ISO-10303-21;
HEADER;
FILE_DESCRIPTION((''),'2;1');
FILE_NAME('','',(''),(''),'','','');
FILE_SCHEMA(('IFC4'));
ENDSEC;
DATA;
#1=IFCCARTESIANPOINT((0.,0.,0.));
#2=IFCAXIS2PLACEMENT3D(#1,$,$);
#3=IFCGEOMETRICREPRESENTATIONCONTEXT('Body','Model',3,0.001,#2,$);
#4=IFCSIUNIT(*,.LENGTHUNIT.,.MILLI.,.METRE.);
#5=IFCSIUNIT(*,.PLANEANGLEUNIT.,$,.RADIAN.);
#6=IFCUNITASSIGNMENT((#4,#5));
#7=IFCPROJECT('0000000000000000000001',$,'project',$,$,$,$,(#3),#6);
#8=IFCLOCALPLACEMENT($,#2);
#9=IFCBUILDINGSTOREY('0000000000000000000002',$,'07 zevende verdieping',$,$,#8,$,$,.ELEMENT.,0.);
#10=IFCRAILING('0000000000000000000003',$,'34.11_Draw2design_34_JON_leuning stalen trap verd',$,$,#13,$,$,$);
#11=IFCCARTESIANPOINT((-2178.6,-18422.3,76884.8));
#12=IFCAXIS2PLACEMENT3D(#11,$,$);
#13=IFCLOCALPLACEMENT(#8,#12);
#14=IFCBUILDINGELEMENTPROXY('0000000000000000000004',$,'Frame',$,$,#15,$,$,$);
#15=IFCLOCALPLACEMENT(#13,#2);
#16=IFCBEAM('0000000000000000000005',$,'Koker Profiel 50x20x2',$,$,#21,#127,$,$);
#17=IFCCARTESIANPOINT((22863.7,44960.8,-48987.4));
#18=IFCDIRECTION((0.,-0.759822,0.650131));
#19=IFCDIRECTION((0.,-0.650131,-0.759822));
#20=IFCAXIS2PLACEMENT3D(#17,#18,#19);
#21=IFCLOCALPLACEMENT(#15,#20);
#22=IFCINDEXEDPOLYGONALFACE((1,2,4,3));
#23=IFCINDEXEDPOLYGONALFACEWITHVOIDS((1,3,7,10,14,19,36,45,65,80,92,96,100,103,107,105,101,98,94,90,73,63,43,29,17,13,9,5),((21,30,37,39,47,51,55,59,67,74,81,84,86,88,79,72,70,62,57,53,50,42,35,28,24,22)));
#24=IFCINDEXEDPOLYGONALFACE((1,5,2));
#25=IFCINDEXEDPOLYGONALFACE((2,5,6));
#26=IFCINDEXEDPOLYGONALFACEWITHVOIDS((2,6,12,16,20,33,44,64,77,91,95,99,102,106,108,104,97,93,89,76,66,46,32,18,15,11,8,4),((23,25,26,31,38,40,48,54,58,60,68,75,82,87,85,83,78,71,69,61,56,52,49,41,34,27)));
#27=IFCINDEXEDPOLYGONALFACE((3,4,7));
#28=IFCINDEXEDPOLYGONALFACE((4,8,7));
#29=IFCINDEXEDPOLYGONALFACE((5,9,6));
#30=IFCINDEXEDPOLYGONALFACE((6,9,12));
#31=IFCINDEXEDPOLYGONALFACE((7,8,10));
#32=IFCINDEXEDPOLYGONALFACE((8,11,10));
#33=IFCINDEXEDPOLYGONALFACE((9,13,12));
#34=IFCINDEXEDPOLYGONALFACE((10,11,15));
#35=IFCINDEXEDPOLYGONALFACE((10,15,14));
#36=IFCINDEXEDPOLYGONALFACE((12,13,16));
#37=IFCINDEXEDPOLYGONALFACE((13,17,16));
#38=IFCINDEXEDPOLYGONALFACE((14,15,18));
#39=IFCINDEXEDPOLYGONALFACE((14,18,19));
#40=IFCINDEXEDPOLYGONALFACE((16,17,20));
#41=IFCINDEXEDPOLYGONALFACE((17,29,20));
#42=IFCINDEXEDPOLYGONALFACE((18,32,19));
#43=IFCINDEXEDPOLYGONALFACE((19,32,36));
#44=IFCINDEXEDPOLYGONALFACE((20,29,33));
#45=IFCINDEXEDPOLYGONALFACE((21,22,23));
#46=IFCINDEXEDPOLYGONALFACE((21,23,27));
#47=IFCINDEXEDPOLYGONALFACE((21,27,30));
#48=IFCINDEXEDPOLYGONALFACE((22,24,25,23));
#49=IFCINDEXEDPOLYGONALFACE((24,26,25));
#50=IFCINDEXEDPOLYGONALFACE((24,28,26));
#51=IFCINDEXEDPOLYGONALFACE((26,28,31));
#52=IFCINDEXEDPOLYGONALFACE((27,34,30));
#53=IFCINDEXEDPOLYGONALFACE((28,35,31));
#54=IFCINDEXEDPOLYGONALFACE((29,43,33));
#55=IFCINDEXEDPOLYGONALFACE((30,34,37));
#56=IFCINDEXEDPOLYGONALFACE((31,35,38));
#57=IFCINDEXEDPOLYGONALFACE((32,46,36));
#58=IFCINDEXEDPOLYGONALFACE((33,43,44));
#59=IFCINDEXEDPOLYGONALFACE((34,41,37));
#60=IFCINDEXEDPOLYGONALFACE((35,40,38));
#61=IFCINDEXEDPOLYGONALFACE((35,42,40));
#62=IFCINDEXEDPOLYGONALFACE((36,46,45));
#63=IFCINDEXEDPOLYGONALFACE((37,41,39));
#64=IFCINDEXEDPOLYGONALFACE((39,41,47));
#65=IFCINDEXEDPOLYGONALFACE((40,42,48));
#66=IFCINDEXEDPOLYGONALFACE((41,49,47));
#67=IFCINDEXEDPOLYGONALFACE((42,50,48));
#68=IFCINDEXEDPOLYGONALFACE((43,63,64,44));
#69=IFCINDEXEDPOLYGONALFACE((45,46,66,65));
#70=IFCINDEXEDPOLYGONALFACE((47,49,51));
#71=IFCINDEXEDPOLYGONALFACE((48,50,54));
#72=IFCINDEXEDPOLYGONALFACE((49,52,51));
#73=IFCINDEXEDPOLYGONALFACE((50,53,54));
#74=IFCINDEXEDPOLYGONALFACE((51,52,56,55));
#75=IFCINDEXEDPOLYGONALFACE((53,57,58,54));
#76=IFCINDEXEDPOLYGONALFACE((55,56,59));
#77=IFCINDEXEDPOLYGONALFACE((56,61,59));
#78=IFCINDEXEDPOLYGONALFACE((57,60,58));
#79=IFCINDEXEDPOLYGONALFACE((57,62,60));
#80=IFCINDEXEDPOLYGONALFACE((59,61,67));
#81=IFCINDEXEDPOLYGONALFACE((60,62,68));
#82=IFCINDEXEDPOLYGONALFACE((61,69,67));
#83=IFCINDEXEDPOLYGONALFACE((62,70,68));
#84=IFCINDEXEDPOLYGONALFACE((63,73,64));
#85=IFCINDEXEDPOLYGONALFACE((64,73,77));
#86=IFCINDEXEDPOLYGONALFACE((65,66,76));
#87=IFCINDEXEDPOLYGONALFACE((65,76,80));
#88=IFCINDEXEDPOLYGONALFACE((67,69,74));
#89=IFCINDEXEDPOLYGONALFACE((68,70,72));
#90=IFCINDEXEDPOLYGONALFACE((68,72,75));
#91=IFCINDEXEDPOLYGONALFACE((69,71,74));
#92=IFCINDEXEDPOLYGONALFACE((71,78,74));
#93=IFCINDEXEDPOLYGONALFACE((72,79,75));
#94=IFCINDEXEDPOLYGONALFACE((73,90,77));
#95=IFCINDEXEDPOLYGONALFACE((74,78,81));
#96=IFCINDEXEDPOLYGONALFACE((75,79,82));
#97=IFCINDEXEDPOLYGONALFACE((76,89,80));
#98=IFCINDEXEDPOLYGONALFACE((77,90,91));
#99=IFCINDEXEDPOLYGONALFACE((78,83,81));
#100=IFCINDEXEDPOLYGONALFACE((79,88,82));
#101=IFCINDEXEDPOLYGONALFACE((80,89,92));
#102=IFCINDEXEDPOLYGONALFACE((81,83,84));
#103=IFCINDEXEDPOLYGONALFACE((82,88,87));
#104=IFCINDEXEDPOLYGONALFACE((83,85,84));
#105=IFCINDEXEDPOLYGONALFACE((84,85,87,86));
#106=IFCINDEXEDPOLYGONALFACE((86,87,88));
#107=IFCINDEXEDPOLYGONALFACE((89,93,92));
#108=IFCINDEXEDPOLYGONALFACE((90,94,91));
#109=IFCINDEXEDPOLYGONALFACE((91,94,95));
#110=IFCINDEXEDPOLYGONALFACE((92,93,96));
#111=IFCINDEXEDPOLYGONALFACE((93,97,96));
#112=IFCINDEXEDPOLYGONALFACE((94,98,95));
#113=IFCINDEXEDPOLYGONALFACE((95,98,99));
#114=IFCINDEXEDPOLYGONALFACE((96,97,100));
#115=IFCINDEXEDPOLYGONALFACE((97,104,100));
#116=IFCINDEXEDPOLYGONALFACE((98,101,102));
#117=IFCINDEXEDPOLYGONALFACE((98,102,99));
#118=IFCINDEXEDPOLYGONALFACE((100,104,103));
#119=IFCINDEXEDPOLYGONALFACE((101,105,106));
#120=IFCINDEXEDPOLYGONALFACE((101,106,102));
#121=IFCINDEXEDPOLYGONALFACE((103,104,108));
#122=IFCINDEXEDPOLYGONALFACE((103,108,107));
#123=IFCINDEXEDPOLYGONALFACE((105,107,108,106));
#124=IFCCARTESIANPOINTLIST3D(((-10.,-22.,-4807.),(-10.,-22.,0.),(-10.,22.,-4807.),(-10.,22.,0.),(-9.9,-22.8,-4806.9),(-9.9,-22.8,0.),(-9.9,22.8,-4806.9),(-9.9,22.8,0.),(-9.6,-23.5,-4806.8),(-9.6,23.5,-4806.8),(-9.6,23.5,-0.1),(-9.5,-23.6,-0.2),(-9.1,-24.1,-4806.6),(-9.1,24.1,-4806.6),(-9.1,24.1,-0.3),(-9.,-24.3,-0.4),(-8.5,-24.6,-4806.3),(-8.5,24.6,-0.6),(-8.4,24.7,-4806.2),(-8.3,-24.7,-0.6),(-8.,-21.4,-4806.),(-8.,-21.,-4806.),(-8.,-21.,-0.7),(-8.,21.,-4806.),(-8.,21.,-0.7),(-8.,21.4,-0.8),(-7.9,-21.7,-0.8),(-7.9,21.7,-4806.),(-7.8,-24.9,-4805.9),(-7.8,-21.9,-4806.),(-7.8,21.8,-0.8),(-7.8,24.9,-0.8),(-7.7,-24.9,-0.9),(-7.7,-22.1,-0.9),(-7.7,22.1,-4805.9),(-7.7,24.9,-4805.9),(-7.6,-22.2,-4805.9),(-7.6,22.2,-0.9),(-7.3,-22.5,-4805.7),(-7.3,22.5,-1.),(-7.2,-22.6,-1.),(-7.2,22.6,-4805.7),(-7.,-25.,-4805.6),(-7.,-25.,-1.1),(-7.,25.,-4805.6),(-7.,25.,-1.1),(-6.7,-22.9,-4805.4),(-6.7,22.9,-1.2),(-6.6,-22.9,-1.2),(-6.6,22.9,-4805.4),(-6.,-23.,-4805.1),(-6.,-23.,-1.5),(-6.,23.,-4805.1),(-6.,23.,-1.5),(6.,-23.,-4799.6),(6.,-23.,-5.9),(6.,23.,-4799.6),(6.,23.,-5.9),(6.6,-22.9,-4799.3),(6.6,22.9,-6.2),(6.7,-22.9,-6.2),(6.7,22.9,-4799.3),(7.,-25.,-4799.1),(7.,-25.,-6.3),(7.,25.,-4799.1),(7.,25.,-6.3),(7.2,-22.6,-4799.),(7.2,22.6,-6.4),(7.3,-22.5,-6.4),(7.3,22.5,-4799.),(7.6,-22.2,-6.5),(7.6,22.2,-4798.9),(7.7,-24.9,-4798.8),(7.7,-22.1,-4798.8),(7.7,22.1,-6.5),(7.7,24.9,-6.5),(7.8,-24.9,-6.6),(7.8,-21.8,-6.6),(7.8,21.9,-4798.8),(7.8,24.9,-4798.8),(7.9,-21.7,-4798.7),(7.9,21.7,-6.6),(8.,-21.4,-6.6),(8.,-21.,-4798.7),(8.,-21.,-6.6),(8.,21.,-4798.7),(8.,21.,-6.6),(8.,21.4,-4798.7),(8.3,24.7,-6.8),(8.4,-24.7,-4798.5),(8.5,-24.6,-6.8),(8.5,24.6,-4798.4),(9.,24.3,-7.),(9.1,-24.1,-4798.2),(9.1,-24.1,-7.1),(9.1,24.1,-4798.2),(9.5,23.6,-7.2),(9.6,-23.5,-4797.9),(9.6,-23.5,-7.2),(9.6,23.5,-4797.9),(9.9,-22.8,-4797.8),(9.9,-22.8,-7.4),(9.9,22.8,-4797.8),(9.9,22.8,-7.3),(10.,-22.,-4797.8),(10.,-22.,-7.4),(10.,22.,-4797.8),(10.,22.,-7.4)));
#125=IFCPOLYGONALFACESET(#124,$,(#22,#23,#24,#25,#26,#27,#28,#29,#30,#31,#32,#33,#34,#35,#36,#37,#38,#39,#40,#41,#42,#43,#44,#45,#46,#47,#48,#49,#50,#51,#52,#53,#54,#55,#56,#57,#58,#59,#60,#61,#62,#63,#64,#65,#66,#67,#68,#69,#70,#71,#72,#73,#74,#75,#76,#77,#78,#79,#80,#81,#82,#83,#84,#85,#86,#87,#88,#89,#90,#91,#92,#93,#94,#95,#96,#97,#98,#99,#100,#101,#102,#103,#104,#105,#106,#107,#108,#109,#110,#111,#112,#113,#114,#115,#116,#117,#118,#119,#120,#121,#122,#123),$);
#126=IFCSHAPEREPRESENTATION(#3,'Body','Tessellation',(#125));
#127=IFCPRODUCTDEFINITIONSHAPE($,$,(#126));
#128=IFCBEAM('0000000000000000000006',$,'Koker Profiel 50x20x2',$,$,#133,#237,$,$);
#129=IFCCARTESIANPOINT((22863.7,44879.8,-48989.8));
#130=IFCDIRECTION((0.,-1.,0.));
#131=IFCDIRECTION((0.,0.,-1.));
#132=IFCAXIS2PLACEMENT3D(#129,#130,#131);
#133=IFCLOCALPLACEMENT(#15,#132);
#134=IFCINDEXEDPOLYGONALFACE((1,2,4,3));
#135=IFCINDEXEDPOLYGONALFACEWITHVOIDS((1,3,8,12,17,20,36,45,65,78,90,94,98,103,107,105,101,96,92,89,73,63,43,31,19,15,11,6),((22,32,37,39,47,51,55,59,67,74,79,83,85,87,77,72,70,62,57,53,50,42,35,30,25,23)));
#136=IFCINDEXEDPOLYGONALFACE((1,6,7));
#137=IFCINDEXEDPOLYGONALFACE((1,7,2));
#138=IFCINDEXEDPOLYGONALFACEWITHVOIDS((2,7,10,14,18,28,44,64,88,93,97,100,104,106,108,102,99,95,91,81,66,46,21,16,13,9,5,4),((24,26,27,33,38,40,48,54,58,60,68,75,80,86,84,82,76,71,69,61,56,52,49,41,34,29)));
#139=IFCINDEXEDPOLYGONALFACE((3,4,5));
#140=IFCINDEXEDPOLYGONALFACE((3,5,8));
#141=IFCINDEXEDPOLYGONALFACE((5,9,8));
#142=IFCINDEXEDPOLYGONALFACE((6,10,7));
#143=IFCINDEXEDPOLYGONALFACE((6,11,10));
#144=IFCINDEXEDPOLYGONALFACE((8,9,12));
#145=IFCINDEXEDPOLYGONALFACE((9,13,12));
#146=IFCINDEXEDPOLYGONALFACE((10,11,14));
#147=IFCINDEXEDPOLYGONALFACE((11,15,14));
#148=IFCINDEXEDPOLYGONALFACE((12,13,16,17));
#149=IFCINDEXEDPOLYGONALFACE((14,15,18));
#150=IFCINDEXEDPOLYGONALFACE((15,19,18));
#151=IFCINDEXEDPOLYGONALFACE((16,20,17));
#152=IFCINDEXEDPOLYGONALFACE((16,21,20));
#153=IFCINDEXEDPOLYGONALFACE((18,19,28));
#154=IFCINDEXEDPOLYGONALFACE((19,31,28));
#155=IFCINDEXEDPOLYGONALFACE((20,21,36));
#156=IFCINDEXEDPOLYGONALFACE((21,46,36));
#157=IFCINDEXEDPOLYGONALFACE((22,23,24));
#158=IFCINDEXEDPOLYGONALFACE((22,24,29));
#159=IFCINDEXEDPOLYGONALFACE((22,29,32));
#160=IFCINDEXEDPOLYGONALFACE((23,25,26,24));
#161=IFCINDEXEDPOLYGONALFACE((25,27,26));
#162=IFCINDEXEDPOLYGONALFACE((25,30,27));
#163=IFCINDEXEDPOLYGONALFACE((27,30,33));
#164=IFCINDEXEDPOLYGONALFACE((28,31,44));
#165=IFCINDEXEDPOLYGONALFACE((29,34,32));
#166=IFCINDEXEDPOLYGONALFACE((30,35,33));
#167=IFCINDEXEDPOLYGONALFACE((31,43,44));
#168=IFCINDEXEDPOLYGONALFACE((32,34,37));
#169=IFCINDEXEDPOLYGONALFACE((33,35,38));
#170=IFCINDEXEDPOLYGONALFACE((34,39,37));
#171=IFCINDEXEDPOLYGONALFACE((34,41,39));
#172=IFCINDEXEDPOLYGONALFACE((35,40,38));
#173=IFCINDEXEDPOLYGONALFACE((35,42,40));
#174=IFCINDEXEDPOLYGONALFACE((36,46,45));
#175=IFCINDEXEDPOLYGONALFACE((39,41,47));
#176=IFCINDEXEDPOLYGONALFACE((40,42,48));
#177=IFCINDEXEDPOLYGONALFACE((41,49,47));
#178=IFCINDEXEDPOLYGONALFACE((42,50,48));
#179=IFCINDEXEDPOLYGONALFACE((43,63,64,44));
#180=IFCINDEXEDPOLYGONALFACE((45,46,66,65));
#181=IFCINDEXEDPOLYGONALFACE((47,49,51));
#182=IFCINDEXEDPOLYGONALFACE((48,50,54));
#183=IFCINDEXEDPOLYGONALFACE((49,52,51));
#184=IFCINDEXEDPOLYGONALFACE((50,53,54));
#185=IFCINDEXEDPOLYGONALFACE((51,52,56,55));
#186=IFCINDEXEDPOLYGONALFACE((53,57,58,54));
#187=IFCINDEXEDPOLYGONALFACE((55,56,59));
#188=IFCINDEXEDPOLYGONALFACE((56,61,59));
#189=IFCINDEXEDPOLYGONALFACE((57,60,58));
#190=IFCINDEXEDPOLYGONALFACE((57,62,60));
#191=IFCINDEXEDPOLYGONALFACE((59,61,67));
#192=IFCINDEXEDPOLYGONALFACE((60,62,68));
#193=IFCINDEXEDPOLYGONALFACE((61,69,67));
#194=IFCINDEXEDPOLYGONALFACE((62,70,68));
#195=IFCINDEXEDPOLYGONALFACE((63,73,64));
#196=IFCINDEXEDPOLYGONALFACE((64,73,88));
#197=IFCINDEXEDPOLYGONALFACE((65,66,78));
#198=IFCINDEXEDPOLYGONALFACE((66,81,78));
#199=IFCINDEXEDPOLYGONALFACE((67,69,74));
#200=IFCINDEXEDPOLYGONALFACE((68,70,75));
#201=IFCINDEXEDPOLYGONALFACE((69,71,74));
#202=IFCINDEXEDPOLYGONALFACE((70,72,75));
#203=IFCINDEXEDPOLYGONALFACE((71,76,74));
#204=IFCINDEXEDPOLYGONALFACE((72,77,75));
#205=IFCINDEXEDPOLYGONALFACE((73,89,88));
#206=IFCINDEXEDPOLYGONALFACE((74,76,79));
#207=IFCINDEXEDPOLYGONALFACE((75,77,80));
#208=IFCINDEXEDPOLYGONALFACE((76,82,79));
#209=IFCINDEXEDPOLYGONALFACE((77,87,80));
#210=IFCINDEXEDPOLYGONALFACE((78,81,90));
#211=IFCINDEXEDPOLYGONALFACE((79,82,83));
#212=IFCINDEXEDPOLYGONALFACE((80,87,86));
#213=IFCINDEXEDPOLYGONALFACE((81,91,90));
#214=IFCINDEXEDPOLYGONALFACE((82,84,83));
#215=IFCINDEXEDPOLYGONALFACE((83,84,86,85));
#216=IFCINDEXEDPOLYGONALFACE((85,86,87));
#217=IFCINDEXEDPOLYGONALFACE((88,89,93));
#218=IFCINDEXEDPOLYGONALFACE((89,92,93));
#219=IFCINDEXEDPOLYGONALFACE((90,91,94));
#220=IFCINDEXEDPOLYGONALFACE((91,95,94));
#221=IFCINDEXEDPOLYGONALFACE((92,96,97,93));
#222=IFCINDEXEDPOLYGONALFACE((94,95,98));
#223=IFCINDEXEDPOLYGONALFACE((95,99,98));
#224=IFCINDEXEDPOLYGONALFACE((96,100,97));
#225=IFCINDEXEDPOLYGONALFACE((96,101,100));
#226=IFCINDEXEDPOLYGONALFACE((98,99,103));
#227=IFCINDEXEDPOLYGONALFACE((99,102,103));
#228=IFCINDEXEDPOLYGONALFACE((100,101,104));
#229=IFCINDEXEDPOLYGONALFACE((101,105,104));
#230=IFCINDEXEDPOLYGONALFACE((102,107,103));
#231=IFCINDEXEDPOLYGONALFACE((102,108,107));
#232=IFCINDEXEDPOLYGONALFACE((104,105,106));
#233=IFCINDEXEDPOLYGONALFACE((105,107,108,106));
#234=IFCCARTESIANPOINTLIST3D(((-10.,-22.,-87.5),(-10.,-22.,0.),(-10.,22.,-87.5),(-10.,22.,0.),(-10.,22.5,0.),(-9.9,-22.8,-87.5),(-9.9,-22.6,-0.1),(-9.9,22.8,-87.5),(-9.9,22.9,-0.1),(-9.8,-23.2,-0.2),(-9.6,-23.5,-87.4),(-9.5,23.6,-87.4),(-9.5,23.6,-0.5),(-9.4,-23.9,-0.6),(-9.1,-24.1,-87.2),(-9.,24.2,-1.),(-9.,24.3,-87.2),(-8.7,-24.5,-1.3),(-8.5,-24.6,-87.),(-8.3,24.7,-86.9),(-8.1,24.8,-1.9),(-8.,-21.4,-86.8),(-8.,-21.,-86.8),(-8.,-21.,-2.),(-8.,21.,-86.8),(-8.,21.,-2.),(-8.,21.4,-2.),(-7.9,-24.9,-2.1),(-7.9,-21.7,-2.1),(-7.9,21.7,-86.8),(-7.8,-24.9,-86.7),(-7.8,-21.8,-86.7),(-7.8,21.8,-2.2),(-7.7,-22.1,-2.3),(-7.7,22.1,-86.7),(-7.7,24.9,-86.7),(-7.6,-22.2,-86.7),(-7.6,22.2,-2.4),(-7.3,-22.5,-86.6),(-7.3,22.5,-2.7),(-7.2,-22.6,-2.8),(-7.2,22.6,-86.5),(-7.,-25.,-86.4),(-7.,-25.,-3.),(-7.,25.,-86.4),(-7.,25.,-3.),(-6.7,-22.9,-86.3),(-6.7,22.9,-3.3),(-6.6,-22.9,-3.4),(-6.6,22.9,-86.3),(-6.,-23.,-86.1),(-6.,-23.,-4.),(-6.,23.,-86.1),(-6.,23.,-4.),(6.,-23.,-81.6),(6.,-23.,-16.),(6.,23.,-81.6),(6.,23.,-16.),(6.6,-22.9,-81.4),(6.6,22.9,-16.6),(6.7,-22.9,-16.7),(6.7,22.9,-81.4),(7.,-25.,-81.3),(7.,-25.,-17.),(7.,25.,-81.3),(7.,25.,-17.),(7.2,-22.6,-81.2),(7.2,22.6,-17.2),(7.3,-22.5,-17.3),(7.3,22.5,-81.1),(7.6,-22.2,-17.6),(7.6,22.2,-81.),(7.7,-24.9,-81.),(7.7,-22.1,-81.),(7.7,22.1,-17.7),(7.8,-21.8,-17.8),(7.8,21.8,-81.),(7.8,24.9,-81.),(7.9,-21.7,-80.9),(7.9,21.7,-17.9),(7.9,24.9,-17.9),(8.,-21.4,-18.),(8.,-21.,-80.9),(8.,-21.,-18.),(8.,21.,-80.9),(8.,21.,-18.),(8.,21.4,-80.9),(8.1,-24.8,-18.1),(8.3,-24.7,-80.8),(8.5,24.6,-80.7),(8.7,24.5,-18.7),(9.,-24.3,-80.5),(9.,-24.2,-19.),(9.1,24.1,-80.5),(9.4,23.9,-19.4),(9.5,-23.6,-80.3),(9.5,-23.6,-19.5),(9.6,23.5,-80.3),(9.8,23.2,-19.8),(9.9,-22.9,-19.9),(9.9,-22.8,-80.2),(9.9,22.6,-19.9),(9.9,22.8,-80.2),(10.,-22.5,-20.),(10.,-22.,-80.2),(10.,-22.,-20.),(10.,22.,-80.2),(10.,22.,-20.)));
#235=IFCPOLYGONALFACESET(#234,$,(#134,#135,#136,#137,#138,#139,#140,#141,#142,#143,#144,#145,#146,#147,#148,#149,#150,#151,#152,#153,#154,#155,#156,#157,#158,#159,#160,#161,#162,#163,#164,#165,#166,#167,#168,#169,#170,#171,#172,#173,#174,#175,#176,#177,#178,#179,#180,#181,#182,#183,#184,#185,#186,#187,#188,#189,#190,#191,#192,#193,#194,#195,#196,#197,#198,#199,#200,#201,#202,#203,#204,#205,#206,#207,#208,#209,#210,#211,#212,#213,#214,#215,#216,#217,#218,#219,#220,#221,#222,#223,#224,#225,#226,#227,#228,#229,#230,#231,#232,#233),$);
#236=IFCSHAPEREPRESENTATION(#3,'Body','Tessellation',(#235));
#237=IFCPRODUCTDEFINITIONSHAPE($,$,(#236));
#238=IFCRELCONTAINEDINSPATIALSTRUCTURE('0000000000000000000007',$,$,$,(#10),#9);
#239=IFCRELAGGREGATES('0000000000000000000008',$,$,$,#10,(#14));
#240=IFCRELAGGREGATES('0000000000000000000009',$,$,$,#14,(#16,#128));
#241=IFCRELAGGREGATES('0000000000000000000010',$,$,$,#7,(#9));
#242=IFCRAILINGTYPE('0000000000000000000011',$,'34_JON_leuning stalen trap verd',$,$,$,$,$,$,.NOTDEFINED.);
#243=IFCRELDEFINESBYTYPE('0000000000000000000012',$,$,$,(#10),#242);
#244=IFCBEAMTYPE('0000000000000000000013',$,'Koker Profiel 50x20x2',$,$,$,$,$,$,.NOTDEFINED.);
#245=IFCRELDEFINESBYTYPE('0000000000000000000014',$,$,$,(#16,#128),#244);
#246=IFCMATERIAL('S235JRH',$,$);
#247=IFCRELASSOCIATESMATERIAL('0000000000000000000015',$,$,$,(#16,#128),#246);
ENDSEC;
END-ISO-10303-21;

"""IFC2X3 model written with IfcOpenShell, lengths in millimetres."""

from ifc_helpers import new_model, si_unit, frame, origin, origin_2d, place, context, project, spatial, hollow_rectangle, extrude, clip, halfspace, source, transform, mapped, material, type_object, element, aggregate, save


model = new_model("IFC2X3")

# Units and contexts
model_context = context("Model", 3, precision=0.001, world=origin(), identifier="Body")
ifc_project = project(units=[si_unit("LENGTHUNIT", "METRE", prefix="MILLI"), si_unit("PLANEANGLEUNIT", "RADIAN")], contexts=[model_context])

# Storey
storey_placement = place(None, origin())
storey = spatial("IfcBuildingStorey", under=ifc_project, at=storey_placement, Name="07 zevende verdieping", CompositionType="ELEMENT", Elevation=0.0)

# Railing
railing_type_1 = type_object("IfcRailingType", Name="34_JON_leuning stalen trap verd")
railing_1_placement = place(storey_placement, frame((-2178.6, -18422.3, 76884.8)))
railing_1 = element("IfcRailing", 1, at=railing_1_placement, inside=storey, type_object=railing_type_1, Name="34.11_Draw2design_34_JON_leuning stalen trap verd")
ifc_material_1 = material(Name="S235JRH")

# Shared definitions
beam_type_1 = type_object("IfcBeamType", Name="Koker Profiel 50x20x2")

# Building element proxy
proxy_1_placement = place(railing_1_placement, origin())
proxy_1 = element("IfcBuildingElementProxy", 2, at=proxy_1_placement, Name="Frame")
aggregate(railing_1, [proxy_1])

# Beams
shared_shape_1 = source(origin(), model_context, "Body", "Clipping", [
    clip(clip(extrude(hollow_rectangle(XDim=20.0, YDim=50.0, WallThickness=2.0, InnerFilletRadius=2.0, OuterFilletRadius=3.0, at=origin_2d()), origin(), (0.0, 0.0, -1.0), 4807.0), halfspace(frame((-8.8, -25.0, -0.5), z_axis=(0.346539, 0.0, 0.938036), x_axis=(0.0, -1.0, 0.0)), False)), halfspace(frame((-8.2, 25.0, -4806.1), z_axis=(0.418252, 0.0, -0.908331), x_axis=(-0.908331, 0.0, -0.418252)), False)),
])
beam_1_placement = place(proxy_1_placement, frame((22863.7, 44960.8, -48987.4), z_axis=(0.0, -0.759822, 0.650131), x_axis=(0.0, -0.650131, -0.759822)))
beam_1 = element("IfcBeam", 3, at=beam_1_placement, type_object=beam_type_1, material=ifc_material_1, Name="Koker Profiel 50x20x2", context=model_context, shape_type="MappedRepresentation", body=[
    mapped(shared_shape_1, transform((0.0, 0.0, 0.0), scale=1.0)),
])
shared_shape_2 = source(origin(), model_context, "Body", "Clipping", [
    clip(clip(extrude(hollow_rectangle(XDim=20.0, YDim=50.0, WallThickness=2.0, InnerFilletRadius=2.0, OuterFilletRadius=3.0, at=origin_2d()), origin(), (0.0, 0.0, -1.0), 87.5), halfspace(frame((-4.1, -25.0, -5.9), z_axis=(0.707107, 0.0, 0.707107), x_axis=(0.707107, 0.0, -0.707107)), False)), halfspace(frame((-8.8, 25.0, -87.1), z_axis=(0.346539, 0.0, -0.938036), x_axis=(0.0, 1.0, 0.0)), False)),
])
beam_2_placement = place(proxy_1_placement, frame((22863.7, 44879.8, -48989.8), z_axis=(0.0, -1.0, 0.0), x_axis=(0.0, 0.0, -1.0)))
beam_2 = element("IfcBeam", 4, at=beam_2_placement, type_object=beam_type_1, material=ifc_material_1, Name="Koker Profiel 50x20x2", context=model_context, shape_type="MappedRepresentation", body=[
    mapped(shared_shape_2, transform((0.0, 0.0, 0.0), scale=1.0)),
])
aggregate(proxy_1, [beam_1, beam_2])

save(model, "model.ifc")
